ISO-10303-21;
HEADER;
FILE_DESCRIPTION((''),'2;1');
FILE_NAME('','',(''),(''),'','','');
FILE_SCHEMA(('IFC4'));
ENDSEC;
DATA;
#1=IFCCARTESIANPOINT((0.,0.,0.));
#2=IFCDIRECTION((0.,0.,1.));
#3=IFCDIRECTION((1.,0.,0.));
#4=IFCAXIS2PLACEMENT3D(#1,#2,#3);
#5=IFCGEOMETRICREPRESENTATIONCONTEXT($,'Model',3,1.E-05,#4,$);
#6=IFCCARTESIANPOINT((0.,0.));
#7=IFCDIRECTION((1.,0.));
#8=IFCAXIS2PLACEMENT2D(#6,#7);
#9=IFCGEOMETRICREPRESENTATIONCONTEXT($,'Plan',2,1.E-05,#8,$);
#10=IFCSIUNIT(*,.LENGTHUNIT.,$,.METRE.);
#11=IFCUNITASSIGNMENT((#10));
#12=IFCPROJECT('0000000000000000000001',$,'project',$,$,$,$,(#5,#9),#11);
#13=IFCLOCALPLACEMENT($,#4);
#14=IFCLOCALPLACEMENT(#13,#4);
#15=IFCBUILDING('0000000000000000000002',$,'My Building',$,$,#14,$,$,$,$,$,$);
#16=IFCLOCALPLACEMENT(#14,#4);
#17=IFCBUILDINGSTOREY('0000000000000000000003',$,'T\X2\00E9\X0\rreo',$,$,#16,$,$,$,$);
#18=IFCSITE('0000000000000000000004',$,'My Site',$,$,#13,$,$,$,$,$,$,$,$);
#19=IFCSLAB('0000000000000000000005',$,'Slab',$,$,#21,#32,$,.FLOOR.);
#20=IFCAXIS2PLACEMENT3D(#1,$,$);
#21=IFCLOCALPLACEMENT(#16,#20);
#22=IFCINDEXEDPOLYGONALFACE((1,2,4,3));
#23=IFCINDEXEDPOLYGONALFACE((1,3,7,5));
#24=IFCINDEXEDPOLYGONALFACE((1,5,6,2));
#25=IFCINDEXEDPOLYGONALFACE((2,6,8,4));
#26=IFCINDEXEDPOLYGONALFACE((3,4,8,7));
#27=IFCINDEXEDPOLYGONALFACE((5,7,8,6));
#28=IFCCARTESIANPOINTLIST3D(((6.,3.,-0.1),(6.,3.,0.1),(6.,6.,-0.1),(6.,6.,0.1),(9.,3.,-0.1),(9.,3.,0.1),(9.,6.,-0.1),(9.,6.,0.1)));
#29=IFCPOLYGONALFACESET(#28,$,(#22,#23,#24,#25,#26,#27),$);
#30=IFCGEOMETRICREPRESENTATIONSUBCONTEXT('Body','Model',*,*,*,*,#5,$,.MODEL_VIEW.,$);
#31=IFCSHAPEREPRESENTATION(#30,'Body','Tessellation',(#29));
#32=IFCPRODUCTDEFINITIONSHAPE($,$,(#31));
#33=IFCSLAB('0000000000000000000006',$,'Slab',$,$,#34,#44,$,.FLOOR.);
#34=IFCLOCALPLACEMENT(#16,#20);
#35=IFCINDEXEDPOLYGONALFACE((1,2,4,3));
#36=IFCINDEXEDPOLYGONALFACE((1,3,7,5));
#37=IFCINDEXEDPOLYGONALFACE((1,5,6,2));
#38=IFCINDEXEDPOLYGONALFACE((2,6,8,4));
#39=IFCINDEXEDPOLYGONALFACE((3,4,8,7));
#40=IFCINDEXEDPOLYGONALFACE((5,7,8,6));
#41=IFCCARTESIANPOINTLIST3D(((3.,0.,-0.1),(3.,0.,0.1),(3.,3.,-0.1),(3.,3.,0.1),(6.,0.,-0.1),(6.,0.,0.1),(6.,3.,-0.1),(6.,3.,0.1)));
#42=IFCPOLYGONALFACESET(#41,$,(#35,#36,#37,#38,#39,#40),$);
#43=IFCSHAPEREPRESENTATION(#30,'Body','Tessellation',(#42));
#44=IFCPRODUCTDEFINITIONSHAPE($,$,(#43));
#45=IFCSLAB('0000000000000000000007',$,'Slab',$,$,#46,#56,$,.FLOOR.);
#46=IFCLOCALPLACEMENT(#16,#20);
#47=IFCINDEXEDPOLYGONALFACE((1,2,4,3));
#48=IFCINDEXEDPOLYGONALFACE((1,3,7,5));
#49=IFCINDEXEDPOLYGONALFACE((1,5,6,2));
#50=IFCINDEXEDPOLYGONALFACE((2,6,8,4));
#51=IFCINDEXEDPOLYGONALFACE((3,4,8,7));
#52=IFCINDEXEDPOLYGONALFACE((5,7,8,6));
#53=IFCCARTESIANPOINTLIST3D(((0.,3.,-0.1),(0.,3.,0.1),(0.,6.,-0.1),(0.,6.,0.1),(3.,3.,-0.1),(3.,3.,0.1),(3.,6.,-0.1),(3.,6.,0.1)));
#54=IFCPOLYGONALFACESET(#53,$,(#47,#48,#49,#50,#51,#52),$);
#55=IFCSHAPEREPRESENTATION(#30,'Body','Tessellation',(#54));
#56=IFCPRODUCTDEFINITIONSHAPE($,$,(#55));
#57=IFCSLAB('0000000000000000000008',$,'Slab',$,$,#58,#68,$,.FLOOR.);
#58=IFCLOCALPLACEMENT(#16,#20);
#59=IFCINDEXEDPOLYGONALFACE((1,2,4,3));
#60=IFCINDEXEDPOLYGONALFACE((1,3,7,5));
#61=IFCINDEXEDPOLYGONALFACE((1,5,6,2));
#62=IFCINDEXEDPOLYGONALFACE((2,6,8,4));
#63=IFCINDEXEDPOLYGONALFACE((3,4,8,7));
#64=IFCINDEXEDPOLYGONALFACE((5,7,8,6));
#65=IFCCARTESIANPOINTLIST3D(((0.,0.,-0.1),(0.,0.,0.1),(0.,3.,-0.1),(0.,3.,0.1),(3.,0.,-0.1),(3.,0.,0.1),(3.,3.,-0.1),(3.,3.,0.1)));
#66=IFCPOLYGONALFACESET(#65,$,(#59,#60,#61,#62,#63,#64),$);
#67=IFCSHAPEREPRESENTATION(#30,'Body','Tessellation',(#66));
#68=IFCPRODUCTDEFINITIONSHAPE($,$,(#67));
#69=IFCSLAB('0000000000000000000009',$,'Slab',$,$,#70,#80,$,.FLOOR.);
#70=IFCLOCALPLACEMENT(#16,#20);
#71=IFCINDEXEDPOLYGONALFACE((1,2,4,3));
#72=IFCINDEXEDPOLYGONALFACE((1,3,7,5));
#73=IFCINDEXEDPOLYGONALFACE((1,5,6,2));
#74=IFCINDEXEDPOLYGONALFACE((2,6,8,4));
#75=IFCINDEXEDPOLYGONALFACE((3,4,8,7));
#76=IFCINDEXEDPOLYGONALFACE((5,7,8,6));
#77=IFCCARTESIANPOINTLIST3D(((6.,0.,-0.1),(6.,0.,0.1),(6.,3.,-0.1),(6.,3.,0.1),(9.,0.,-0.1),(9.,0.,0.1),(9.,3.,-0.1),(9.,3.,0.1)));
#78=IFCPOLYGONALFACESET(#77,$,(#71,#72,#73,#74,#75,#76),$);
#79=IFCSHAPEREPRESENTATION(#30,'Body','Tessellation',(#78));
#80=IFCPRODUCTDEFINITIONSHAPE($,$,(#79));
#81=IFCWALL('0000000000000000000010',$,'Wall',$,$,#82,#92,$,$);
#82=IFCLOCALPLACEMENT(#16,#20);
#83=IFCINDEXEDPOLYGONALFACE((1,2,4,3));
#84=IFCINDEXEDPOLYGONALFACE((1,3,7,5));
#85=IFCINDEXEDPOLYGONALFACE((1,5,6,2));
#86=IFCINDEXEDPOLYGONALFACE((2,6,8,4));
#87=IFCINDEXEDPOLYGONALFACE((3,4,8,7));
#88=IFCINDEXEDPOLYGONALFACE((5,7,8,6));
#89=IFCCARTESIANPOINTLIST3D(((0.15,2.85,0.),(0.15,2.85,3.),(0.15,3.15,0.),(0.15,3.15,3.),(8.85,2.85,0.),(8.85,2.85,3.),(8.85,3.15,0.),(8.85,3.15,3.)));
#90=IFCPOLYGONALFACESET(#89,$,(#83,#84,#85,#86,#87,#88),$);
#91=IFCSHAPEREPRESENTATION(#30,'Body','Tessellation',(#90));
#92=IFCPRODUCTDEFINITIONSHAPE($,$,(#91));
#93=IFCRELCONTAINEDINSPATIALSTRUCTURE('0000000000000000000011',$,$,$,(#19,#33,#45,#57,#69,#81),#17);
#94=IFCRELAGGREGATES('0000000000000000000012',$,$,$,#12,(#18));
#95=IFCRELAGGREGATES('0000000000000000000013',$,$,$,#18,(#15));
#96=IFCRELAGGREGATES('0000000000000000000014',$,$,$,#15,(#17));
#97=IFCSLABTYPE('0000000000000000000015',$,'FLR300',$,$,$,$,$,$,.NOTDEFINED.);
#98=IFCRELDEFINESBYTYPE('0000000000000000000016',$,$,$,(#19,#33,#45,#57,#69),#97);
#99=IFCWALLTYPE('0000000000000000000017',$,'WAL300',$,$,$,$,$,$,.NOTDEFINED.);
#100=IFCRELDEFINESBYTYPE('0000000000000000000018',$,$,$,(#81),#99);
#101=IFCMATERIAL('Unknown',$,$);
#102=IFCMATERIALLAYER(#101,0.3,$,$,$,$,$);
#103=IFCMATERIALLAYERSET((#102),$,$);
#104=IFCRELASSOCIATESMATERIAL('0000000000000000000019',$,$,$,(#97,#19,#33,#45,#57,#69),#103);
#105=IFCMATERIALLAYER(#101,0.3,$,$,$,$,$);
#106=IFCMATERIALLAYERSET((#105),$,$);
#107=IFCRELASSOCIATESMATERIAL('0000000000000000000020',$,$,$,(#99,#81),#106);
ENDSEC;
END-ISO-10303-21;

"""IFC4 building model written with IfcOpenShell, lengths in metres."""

from ifc_helpers import new_model, si_unit, frame, origin, origin_with_axes, origin_2d_with_axis, place, context, subcontext, project, spatial, polyline, line, indexed_curve, outline, extrude, material, layer, layer_set, layer_usage, type_object, element, save


model = new_model("IFC4")

# Units and contexts
model_context = context("Model", 3, precision=1e-05, world=origin_with_axes())
plan_context = context("Plan", 2, precision=1e-05, world=origin_2d_with_axis())
body_context_1 = subcontext(model_context, "Body", "Model", "MODEL_VIEW")
ifc_project = project(units=[si_unit("LENGTHUNIT", "METRE")], contexts=[model_context, plan_context])

# Site, building, storey
site_placement = place(None, origin_with_axes())
site = spatial("IfcSite", under=ifc_project, at=site_placement, Name="My Site")
building_placement = place(site_placement, origin_with_axes())
building = spatial("IfcBuilding", under=site, at=building_placement, Name="My Building")
storey_placement = place(building_placement, origin_with_axes())
storey = spatial("IfcBuildingStorey", under=building, at=storey_placement, Name="Térreo")

# Slabs
ifc_material = material(Name="Unknown")
ifc_layer_1 = layer(ifc_material, 0.3)
ifc_layer_set_1 = layer_set([ifc_layer_1])
ifc_layer_usage_1 = layer_usage(ifc_layer_set_1, "AXIS3", "POSITIVE", 0.0)
slab_type = type_object("IfcSlabType", Name="FLR300", PredefinedType="NOTDEFINED", material=ifc_layer_set_1)
slab_1_placement = place(storey_placement, frame((7.5, 4.5, -0.1), z_axis=(0.0, 0.0, 1.0), x_axis=(1.0, 0.0, 0.0)))
element("IfcSlab", 1, at=slab_1_placement, inside=storey, type_object=slab_type, material=ifc_layer_usage_1, Name="Slab", PredefinedType="FLOOR", context=body_context_1, shape_type="SweptSolid", body=[
    extrude(outline(polyline([(-1.5, 1.5), (-1.5, -1.5), (1.5, -1.5), (1.5, 1.5), (-1.5, 1.5)])), origin(), (0.0, 0.0, 1.0), 0.2),
])
ifc_layer_usage_2 = layer_usage(ifc_layer_set_1, "AXIS3", "POSITIVE", 0.0)
slab_2_placement = place(storey_placement, frame((4.5, 1.5, -0.1), z_axis=(0.0, 0.0, 1.0), x_axis=(1.0, 0.0, 0.0)))
element("IfcSlab", 2, at=slab_2_placement, inside=storey, type_object=slab_type, material=ifc_layer_usage_2, Name="Slab", PredefinedType="FLOOR", context=body_context_1, shape_type="SweptSolid", body=[
    extrude(outline(polyline([(-1.5, 1.5), (-1.5, -1.5), (1.5, -1.5), (1.5, 1.5), (-1.5, 1.5)])), origin(), (0.0, 0.0, 1.0), 0.2),
])
ifc_layer_usage_3 = layer_usage(ifc_layer_set_1, "AXIS3", "POSITIVE", 0.0)
slab_3_placement = place(storey_placement, frame((1.5, 4.5, -0.1), z_axis=(0.0, 0.0, 1.0), x_axis=(1.0, 0.0, 0.0)))
element("IfcSlab", 3, at=slab_3_placement, inside=storey, type_object=slab_type, material=ifc_layer_usage_3, Name="Slab", PredefinedType="FLOOR", context=body_context_1, shape_type="SweptSolid", body=[
    extrude(outline(polyline([(-1.5, 1.5), (-1.5, -1.5), (1.5, -1.5), (1.5, 1.5), (-1.5, 1.5)])), origin(), (0.0, 0.0, 1.0), 0.2),
])
ifc_layer_usage_4 = layer_usage(ifc_layer_set_1, "AXIS3", "POSITIVE", 0.0)
slab_4_placement = place(storey_placement, frame((1.5, 1.5, -0.1), z_axis=(0.0, 0.0, 1.0), x_axis=(1.0, 0.0, 0.0)))
element("IfcSlab", 4, at=slab_4_placement, inside=storey, type_object=slab_type, material=ifc_layer_usage_4, Name="Slab", PredefinedType="FLOOR", context=body_context_1, shape_type="SweptSolid", body=[
    extrude(outline(polyline([(-1.5, 1.5), (-1.5, -1.5), (1.5, -1.5), (1.5, 1.5), (-1.5, 1.5)])), origin(), (0.0, 0.0, 1.0), 0.2),
])
ifc_layer_usage_5 = layer_usage(ifc_layer_set_1, "AXIS3", "POSITIVE", 0.0)
slab_5_placement = place(storey_placement, frame((7.5, 1.5, -0.1), z_axis=(0.0, 0.0, 1.0), x_axis=(1.0, 0.0, 0.0)))
element("IfcSlab", 5, at=slab_5_placement, inside=storey, type_object=slab_type, material=ifc_layer_usage_5, Name="Slab", PredefinedType="FLOOR", context=body_context_1, shape_type="SweptSolid", body=[
    extrude(outline(polyline([(-1.5, 1.5), (-1.5, -1.5), (1.5, -1.5), (1.5, 1.5), (-1.5, 1.5)])), origin(), (0.0, 0.0, 1.0), 0.2),
])

# Shared definitions
ifc_layer_2 = layer(ifc_material, 0.3)
ifc_layer_set_2 = layer_set([ifc_layer_2])
wall_type = type_object("IfcWallType", Name="WAL300", PredefinedType="NOTDEFINED", material=ifc_layer_set_2)

# Wall
ifc_layer_usage_6 = layer_usage(ifc_layer_set_2, "AXIS2", "POSITIVE", -0.15)
wall_1_placement = place(storey_placement, frame((0.0, 3.0, 0.0), z_axis=(0.0, 0.0, 1.0), x_axis=(1.0, 0.0, 0.0)))
element("IfcWall", 6, at=wall_1_placement, inside=storey, type_object=wall_type, material=ifc_layer_usage_6, Name="Wall", context=body_context_1, shape_type="SweptSolid", body=[
    extrude(outline(indexed_curve([(0.15, -0.15), (0.15, 0.15), (8.85, 0.15), (8.85, -0.15)], segments=[line(1, 2, 3, 4, 1)])), origin_with_axes(), (0.0, 0.0, 1.0), 3.0),
])

save(model, "model.ifc")
